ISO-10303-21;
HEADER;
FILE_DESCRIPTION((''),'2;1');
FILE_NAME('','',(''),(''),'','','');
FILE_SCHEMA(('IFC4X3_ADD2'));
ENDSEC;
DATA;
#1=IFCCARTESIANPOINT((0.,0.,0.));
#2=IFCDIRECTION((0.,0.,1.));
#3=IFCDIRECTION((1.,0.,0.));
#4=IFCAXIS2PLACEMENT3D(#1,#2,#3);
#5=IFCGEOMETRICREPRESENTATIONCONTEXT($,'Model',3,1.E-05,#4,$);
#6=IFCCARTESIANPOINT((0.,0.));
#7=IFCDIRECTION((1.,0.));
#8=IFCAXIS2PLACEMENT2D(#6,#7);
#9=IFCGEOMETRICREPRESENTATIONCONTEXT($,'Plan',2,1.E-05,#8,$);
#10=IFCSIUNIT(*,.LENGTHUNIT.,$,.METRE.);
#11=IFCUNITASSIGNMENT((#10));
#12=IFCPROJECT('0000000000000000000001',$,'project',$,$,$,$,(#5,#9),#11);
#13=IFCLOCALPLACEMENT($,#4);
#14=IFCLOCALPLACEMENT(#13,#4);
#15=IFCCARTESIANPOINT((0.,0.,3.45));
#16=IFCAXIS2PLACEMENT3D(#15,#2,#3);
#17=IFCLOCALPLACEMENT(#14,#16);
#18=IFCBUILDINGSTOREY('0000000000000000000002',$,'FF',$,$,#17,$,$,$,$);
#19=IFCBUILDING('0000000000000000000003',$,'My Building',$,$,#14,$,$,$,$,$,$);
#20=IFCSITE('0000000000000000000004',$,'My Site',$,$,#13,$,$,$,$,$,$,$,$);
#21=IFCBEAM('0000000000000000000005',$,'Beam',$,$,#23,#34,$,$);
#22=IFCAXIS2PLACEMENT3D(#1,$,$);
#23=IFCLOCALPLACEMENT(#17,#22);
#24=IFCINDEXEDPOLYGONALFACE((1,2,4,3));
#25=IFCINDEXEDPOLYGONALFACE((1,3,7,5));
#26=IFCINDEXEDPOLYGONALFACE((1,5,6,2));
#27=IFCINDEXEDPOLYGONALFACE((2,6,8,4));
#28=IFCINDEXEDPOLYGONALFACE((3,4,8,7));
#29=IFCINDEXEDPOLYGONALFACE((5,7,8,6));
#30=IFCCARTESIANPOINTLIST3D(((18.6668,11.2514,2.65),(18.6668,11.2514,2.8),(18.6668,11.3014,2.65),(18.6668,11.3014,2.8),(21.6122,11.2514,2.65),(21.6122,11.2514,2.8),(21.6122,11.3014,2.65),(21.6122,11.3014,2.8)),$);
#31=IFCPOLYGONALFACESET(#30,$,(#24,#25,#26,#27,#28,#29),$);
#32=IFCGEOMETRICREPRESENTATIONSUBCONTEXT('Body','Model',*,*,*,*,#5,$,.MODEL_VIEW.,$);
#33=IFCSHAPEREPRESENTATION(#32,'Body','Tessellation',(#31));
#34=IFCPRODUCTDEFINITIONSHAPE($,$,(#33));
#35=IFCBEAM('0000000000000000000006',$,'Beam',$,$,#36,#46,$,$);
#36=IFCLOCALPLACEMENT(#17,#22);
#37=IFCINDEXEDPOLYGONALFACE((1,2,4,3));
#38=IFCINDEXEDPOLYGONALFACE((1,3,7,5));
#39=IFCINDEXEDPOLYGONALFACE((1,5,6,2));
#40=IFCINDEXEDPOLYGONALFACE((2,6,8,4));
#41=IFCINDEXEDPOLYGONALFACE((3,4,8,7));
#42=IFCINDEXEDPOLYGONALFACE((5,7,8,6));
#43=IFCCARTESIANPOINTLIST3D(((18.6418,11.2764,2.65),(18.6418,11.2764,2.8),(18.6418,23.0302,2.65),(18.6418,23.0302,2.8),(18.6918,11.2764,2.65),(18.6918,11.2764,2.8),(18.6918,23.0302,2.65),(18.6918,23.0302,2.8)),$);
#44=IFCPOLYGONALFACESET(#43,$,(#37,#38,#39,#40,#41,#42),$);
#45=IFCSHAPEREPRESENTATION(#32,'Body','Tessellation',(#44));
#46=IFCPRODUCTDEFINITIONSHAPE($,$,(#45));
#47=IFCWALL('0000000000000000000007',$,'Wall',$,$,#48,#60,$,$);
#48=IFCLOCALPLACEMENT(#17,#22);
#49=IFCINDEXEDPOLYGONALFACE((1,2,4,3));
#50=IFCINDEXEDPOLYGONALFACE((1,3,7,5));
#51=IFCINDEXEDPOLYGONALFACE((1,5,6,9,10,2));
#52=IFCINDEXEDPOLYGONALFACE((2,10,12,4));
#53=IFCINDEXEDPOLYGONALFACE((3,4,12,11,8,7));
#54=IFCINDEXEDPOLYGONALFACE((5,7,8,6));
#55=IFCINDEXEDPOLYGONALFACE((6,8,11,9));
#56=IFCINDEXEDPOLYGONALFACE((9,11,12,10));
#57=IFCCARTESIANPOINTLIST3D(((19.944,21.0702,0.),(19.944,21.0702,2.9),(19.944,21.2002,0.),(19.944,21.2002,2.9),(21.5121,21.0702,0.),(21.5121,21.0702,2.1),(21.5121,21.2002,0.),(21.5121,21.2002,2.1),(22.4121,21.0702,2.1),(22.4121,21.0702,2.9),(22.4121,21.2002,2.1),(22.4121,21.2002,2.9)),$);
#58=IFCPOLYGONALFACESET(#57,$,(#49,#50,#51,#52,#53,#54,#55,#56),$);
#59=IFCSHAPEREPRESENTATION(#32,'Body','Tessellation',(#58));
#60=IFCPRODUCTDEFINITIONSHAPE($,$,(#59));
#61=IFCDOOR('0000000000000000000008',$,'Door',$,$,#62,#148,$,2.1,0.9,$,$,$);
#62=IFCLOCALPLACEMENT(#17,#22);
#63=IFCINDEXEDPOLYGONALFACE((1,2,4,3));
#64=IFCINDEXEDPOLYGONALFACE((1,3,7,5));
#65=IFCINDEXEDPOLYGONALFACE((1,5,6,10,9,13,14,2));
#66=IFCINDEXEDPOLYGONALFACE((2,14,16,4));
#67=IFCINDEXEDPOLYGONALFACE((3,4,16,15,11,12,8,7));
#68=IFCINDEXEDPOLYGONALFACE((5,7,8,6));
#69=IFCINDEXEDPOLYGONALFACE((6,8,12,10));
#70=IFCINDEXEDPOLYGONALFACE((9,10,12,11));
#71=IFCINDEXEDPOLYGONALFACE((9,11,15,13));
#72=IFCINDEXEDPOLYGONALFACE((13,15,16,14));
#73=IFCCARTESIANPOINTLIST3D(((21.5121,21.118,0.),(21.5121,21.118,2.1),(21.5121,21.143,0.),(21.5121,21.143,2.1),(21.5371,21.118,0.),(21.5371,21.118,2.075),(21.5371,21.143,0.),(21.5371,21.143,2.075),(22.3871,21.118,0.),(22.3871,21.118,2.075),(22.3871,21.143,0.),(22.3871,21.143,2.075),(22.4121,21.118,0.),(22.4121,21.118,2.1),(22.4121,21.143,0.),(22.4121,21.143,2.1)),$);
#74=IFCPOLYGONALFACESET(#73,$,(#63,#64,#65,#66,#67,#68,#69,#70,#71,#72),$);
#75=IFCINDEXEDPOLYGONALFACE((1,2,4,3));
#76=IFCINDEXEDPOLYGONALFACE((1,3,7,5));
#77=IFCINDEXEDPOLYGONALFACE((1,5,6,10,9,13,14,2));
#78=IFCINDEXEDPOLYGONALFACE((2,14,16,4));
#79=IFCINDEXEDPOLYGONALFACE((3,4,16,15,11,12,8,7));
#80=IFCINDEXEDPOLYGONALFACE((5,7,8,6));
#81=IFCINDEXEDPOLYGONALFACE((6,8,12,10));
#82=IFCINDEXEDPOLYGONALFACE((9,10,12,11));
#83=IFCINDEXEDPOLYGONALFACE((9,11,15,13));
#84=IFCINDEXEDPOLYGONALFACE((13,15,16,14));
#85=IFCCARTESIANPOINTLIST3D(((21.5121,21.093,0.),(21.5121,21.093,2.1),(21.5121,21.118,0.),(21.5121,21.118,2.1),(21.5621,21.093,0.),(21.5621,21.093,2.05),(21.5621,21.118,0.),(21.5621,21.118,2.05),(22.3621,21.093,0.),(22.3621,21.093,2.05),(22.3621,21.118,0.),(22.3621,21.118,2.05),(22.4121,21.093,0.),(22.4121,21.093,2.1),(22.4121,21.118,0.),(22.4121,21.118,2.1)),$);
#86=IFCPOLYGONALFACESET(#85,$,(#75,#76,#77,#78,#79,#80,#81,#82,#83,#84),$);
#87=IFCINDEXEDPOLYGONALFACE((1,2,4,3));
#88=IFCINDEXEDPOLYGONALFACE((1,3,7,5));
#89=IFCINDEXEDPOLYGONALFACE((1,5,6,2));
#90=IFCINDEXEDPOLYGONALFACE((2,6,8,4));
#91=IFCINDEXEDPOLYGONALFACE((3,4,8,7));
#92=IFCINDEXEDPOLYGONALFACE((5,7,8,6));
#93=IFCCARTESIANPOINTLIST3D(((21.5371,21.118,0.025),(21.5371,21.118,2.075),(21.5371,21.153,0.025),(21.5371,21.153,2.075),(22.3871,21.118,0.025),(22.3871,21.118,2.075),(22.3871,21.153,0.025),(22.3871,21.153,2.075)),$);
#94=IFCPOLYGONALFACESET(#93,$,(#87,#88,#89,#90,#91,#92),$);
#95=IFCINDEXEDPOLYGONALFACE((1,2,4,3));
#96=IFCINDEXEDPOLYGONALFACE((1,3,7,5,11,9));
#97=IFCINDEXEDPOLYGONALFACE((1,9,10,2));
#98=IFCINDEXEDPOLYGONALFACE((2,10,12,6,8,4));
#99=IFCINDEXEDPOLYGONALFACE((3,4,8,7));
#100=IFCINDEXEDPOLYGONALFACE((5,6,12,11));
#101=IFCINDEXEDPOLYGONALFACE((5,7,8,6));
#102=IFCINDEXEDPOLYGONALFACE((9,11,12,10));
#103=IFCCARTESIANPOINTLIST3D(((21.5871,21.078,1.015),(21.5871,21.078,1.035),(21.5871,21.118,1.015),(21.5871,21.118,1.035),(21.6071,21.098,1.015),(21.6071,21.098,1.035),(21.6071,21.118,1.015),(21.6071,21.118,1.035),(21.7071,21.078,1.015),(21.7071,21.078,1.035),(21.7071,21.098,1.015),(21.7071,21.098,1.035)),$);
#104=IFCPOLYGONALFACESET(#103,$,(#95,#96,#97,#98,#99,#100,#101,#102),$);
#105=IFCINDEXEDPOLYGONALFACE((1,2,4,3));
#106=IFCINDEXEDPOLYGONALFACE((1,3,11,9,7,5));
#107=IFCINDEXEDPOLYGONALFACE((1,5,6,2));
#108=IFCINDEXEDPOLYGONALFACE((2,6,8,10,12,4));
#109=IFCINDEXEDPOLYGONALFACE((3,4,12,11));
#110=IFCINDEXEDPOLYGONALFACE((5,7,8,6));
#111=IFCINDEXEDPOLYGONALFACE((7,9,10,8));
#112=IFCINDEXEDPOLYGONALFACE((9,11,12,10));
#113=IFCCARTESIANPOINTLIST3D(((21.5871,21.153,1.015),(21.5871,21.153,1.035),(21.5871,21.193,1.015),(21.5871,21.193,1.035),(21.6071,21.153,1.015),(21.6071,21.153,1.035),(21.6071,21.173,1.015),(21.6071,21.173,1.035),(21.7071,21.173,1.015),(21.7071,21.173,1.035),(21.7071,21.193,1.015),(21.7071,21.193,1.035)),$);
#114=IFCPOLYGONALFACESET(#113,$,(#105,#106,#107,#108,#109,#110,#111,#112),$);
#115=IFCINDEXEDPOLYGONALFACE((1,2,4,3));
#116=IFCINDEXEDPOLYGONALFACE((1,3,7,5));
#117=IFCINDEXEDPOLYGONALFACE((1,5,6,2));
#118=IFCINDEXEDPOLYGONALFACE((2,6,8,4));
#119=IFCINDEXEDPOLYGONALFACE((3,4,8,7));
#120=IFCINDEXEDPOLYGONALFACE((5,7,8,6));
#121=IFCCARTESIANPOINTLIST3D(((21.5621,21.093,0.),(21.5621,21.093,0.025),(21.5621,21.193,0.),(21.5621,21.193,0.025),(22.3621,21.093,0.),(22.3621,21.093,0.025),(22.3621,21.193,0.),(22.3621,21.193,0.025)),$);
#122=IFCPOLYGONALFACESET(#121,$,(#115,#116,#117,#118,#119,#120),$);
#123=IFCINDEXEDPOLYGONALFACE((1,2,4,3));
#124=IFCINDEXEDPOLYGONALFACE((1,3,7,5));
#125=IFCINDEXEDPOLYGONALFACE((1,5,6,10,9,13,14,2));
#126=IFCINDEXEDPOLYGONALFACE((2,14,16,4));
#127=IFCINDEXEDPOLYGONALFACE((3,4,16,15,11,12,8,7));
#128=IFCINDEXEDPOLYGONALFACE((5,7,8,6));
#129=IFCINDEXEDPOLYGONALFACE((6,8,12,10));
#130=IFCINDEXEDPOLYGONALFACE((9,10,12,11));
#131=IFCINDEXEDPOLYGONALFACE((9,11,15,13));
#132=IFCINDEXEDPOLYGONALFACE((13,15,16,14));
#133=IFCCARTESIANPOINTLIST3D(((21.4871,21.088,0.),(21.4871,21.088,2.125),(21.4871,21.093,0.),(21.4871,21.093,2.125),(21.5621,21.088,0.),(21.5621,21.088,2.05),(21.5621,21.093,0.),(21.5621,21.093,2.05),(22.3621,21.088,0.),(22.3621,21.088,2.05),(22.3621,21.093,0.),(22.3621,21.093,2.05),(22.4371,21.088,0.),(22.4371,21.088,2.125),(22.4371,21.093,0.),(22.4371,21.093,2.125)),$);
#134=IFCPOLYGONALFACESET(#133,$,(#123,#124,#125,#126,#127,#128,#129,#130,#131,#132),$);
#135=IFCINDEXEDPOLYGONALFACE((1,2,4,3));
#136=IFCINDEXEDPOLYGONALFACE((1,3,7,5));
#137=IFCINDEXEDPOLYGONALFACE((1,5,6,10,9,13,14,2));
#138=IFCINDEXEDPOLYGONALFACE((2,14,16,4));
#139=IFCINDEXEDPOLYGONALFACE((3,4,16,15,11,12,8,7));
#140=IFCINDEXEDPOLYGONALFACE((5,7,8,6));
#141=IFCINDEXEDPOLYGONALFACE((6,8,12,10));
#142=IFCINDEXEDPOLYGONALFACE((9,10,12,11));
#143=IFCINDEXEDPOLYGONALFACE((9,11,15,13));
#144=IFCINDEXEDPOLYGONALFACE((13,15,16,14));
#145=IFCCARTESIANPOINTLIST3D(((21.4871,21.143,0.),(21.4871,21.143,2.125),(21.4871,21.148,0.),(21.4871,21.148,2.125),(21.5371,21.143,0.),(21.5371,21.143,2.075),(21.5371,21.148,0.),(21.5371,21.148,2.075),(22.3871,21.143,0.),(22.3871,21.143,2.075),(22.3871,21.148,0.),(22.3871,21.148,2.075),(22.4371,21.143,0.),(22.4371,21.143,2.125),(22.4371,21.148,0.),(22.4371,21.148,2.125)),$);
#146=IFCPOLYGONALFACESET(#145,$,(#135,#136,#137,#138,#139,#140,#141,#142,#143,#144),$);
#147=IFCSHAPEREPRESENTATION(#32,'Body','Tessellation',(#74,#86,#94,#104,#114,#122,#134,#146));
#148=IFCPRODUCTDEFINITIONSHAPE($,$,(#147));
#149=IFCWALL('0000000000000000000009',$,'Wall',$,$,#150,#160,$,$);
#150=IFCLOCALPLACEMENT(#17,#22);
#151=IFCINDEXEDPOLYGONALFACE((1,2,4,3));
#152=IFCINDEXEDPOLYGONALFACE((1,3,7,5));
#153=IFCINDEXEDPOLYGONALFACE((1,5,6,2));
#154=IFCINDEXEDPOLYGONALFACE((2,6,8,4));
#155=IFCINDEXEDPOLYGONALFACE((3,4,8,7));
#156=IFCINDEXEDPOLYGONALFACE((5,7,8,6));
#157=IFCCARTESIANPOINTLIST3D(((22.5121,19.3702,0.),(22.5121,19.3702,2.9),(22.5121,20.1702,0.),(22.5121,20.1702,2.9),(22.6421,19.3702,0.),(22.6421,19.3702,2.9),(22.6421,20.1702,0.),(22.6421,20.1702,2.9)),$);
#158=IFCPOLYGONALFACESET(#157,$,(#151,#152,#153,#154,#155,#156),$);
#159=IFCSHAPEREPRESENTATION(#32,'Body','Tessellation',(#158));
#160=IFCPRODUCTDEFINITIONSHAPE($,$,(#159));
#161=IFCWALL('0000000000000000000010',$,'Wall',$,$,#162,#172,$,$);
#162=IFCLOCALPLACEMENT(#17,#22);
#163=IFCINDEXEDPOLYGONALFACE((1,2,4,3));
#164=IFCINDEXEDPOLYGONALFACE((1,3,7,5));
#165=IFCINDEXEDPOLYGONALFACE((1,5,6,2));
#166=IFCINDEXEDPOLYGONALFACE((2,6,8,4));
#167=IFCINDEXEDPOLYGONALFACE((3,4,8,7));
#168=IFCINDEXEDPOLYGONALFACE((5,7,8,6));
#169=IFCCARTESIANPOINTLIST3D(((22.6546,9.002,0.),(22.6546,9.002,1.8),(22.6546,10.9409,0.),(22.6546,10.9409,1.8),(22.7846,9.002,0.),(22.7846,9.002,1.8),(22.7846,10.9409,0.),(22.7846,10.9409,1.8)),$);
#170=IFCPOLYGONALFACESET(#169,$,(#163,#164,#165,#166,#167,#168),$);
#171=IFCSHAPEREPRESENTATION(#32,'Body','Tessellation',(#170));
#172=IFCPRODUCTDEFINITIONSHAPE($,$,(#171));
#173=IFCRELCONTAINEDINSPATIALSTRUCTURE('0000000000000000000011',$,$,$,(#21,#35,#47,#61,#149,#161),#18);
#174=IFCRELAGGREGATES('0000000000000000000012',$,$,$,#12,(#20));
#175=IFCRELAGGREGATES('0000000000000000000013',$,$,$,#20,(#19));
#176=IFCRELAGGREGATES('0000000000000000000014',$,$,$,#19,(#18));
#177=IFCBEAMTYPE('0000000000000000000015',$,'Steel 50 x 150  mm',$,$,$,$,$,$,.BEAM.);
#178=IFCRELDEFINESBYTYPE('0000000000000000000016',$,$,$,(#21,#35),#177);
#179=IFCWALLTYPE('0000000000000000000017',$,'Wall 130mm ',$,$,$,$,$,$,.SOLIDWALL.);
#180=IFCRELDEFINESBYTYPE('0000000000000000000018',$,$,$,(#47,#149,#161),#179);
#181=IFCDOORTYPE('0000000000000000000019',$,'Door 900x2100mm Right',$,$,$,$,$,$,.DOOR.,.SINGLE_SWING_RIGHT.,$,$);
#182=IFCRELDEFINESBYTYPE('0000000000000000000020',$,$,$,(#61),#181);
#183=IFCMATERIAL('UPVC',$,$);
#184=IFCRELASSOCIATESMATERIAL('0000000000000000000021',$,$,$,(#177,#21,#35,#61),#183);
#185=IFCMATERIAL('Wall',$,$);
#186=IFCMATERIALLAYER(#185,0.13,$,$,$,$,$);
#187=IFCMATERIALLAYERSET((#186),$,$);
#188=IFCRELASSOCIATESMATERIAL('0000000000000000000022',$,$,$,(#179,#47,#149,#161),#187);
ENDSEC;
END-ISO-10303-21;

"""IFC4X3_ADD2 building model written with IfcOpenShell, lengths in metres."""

from ifc_helpers import new_model, entity, si_unit, frame, origin_with_axes, origin_2d_with_axis, place, context, subcontext, project, spatial, line, indexed_curve, rectangle, outline, extrude, shape, source, transform, mapped, material, layer, layer_set, layer_usage, material_profile, profile_set, profile_usage, type_object, type_shapes, element, fill, save


model = new_model("IFC4X3_ADD2")

# Units and contexts
model_context = context("Model", 3, precision=1e-05, world=origin_with_axes())
plan_context = context("Plan", 2, precision=1e-05, world=origin_2d_with_axis())
body_context_1 = subcontext(model_context, "Body", "Model", "MODEL_VIEW")
body_context_2 = subcontext(plan_context, "Body", "Plan", "PLAN_VIEW")
ifc_project = project(units=[si_unit("LENGTHUNIT", "METRE")], contexts=[model_context, plan_context])

# Site, building, storey
site_placement = place(None, origin_with_axes())
site = spatial("IfcSite", under=ifc_project, at=site_placement, Name="My Site")
building_placement = place(site_placement, origin_with_axes())
building = spatial("IfcBuilding", under=site, at=building_placement, Name="My Building")
storey_placement = place(building_placement, frame((0.0, 0.0, 3.45), z_axis=(0.0, 0.0, 1.0), x_axis=(1.0, 0.0, 0.0)))
storey = spatial("IfcBuildingStorey", under=building, at=storey_placement, Name="FF")

# Beams
ifc_material_1 = material(Name="UPVC")
ifc_material_profile = material_profile(ifc_material_1, rectangle(XDim=0.05, YDim=0.15))
ifc_profile_set = profile_set([ifc_material_profile])
ifc_profile_usage_1 = profile_usage(ifc_profile_set)
beam_type = type_object("IfcBeamType", Name="Steel 50 x 150  mm", PredefinedType="BEAM", material=ifc_profile_set)
beam_1_placement = place(storey_placement, frame((18.6668, 11.2764, 2.725), z_axis=(1.0, 0.0, 0.0), x_axis=(0.0, 1.0, 0.0)))
element("IfcBeam", 1, at=beam_1_placement, inside=storey, type_object=beam_type, material=ifc_profile_usage_1, Name="Beam", context=body_context_1, shape_type="SweptSolid", body=[
    extrude(rectangle(XDim=0.05, YDim=0.15), origin_with_axes(), (0.0, 0.0, 1.0), 2.9454),
])
ifc_profile_usage_2 = profile_usage(ifc_profile_set)
beam_2_placement = place(storey_placement, frame((18.6668, 11.2764, 2.725), z_axis=(0.0, 1.0, 0.0), x_axis=(-1.0, 0.0, 0.0)))
element("IfcBeam", 2, at=beam_2_placement, inside=storey, type_object=beam_type, material=ifc_profile_usage_2, Name="Beam", context=body_context_1, shape_type="SweptSolid", body=[
    extrude(rectangle(XDim=0.05, YDim=0.15), origin_with_axes(), (0.0, 0.0, 1.0), 11.7538),
])

# Wall, opening, door
ifc_material_2 = material(Name="Wall")
ifc_layer_1 = layer(ifc_material_2, 0.13)
ifc_layer_set_1 = layer_set([ifc_layer_1])
ifc_layer_usage_1 = layer_usage(ifc_layer_set_1, "AXIS2", "POSITIVE", 0.0)
wall_type_1 = type_object("IfcWallType", Name="Wall 130mm ", PredefinedType="SOLIDWALL", material=ifc_layer_set_1)
wall_1_placement = place(storey_placement, frame((22.4121, 21.2002, 0.0), z_axis=(0.0, 0.0, 1.0), x_axis=(-1.0, 0.0, 0.0)))
wall_1 = element("IfcWall", 3, at=wall_1_placement, inside=storey, type_object=wall_type_1, material=ifc_layer_usage_1, Name="Wall", context=body_context_1, shape_type="SweptSolid", body=[
    extrude(outline(indexed_curve([(0.0, 0.0), (0.0, 0.13), (2.4681, 0.13), (2.4681, 0.0), (0.0, 0.0)], self_intersect=False)), origin_with_axes(), (0.0, 0.0, 1.0), 2.9),
])
shared_shape_1 = source(origin_with_axes(), body_context_1, "Body", "SweptSolid", [
    extrude(outline(indexed_curve([(0.0, 0.0), (0.9, 0.0), (0.9, 2.1), (0.0, 2.1)], segments=[line(1, 2, 3, 4, 1)])), frame((0.0, -0.6, 0.0), z_axis=(0.0, -1.0, 0.0), x_axis=(1.0, 0.0, 0.0)), (0.0, 0.0, -1.0), 1.2),
])
opening_1_placement = place(wall_1_placement, frame((0.9, 0.1072, 0.0), z_axis=(0.0, 0.0, 1.0), x_axis=(-1.0, 0.0, 0.0)))
opening_1 = element("IfcOpeningElement", 4, at=opening_1_placement, cuts=wall_1, PredefinedType="OPENING", context=body_context_1, shape_type="MappedRepresentation", body=[
    mapped(shared_shape_1, transform((0.0, 0.0, 0.0), x_axis=(1.0, 0.0, 0.0), y_axis=(0.0, 1.0, 0.0), z_axis=(0.0, 0.0, 1.0), scale=1.0)),
])
door_type_1 = type_object("IfcDoorType", Name="Door 900x2100mm Right", OperationType="SINGLE_SWING_RIGHT", PredefinedType="DOOR")
shared_shape_2 = source(origin_with_axes(), body_context_1, "Body", "SweptSolid", [
    extrude(outline(indexed_curve([(0.0, 0.0), (0.0, 2.1), (0.9, 2.1), (0.9, 0.0), (0.875, 0.0), (0.875, 2.075), (0.025, 2.075), (0.025, 0.0)], segments=[line(1, 2, 3, 4, 5, 6, 7, 8, 1)])), frame((0.0, 0.025, 0.0), z_axis=(0.0, -1.0, 0.0), x_axis=(1.0, 0.0, 0.0)), (0.0, 0.0, -1.0), 0.025),
    extrude(outline(indexed_curve([(0.0, 0.0), (0.0, 2.1), (0.9, 2.1), (0.9, 0.0), (0.85, 0.0), (0.85, 2.05), (0.05, 2.05), (0.05, 0.0)], segments=[line(1, 2, 3, 4, 5, 6, 7, 8, 1)])), frame((0.0, 0.0, 0.0), z_axis=(0.0, -1.0, 0.0), x_axis=(1.0, 0.0, 0.0)), (0.0, 0.0, -1.0), 0.025),
    extrude(outline(indexed_curve([(0.0, 0.0), (0.85, 0.0), (0.85, 0.035), (0.0, 0.035)], segments=[line(1, 2, 3, 4, 1)])), frame((0.025, 0.025, 0.025), z_axis=(0.0, 0.0, 1.0), x_axis=(1.0, 0.0, 0.0)), (0.0, 0.0, 1.0), 2.05),
    extrude(outline(indexed_curve([(0.0, 0.0), (0.0, -0.04), (0.12, -0.04), (0.12, -0.02), (0.02, -0.02), (0.02, 0.0)], segments=[line(1, 2, 3, 4, 5, 6, 1)])), frame((0.075, 0.025, 1.015), z_axis=(0.0, 0.0, 1.0), x_axis=(1.0, 0.0, 0.0)), (0.0, 0.0, 1.0), 0.02),
    extrude(outline(indexed_curve([(0.0, 0.0), (0.0, 0.04), (0.12, 0.04), (0.12, 0.02), (0.02, 0.02), (0.02, 0.0)], segments=[line(1, 2, 3, 4, 5, 6, 1)])), frame((0.075, 0.06, 1.015), z_axis=(0.0, 0.0, 1.0), x_axis=(1.0, 0.0, 0.0)), (0.0, 0.0, 1.0), 0.02),
    extrude(outline(indexed_curve([(0.0, 0.0), (0.8, 0.0), (0.8, 0.1), (0.0, 0.1)], segments=[line(1, 2, 3, 4, 1)])), frame((0.05, 0.0, 0.0), z_axis=(0.0, 0.0, 1.0), x_axis=(1.0, 0.0, 0.0)), (0.0, 0.0, 1.0), 0.025),
    extrude(outline(indexed_curve([(0.0, 0.0), (0.0, 2.125), (0.95, 2.125), (0.95, 0.0), (0.875, 0.0), (0.875, 2.05), (0.075, 2.05), (0.075, 0.0)], segments=[line(1, 2, 3, 4, 5, 6, 7, 8, 1)])), frame((-0.025, -0.005, 0.0), z_axis=(0.0, -1.0, 0.0), x_axis=(1.0, 0.0, 0.0)), (0.0, 0.0, -1.0), 0.005),
    extrude(outline(indexed_curve([(0.0, 0.0), (0.0, 2.125), (0.95, 2.125), (0.95, 0.0), (0.9, 0.0), (0.9, 2.075), (0.05, 2.075), (0.05, 0.0)], segments=[line(1, 2, 3, 4, 5, 6, 7, 8, 1)])), frame((-0.025, 0.05, 0.0), z_axis=(0.0, -1.0, 0.0), x_axis=(1.0, 0.0, 0.0)), (0.0, 0.0, -1.0), 0.005),
])
shared_shape_3 = source(origin_with_axes(), body_context_2, "Body", "Curve2D", [
    entity("IfcIndexedPolyCurve", entity("IfcCartesianPointList2D", [[0.0, 0.0], [0.0, 0.05], [0.025, 0.05], [0.025, 0.025], [0.05, 0.025], [0.05, 0.0]]), [entity("IfcLineIndex", [1, 2, 3, 4, 5, 6, 1])]),
    entity("IfcIndexedPolyCurve", entity("IfcCartesianPointList2D", [[0.9, 0.0], [0.9, 0.05], [0.875, 0.05], [0.875, 0.025], [0.85, 0.025], [0.85, 0.0]]), [entity("IfcLineIndex", [1, 2, 3, 4, 5, 6, 1])]),
    entity("IfcTrimmedCurve", entity("IfcEllipse", entity("IfcAxis2Placement2D", entity("IfcCartesianPoint", [0.84, 0.05]), entity("IfcDirection", [1.0, 0.0])), 0.815, 0.85), [entity("IfcCartesianPoint", [0.84, 0.9])], [entity("IfcCartesianPoint", [0.025, 0.05])], True, "CARTESIAN"),
    entity("IfcIndexedPolyCurve", entity("IfcCartesianPointList2D", [[0.875, 0.05], [0.84, 0.05], [0.84, 0.9], [0.875, 0.9]]), [entity("IfcLineIndex", [1, 2, 3, 4, 1])]),
])
type_shapes(door_type_1, [shared_shape_2, shared_shape_3])
door_1_placement = place(opening_1_placement, frame((0.0, 0.0, 0.0), z_axis=(0.0, 0.0, 1.0), x_axis=(1.0, 0.0, 0.0)))
door_1 = element("IfcDoor", 5, at=door_1_placement, inside=storey, type_object=door_type_1, material=ifc_material_1, Name="Door", OverallHeight=2.1, OverallWidth=0.9, shapes=[
    shape(body_context_1, "Body", "MappedRepresentation", [mapped(shared_shape_2, transform((0.0, 0.0, 0.0), x_axis=(1.0, 0.0, 0.0), y_axis=(0.0, 1.0, 0.0), z_axis=(0.0, 0.0, 1.0), scale=1.0))]),
    shape(body_context_2, "Body", "MappedRepresentation", [mapped(shared_shape_3, transform((0.0, 0.0, 0.0), x_axis=(1.0, 0.0, 0.0), y_axis=(0.0, 1.0, 0.0), z_axis=(0.0, 0.0, 1.0), scale=1.0))]),
])
fill(opening_1, door_1)

# Walls
ifc_layer_usage_2 = layer_usage(ifc_layer_set_1, "AXIS2", "POSITIVE", 0.0)
wall_2_placement = place(storey_placement, frame((22.6421, 19.3702, 0.0), z_axis=(0.0, 0.0, 1.0), x_axis=(0.000001, 1.0, 0.0)))
element("IfcWall", 6, at=wall_2_placement, inside=storey, type_object=wall_type_1, material=ifc_layer_usage_2, Name="Wall", context=body_context_1, shape_type="SweptSolid", body=[
    extrude(outline(indexed_curve([(0.0, 0.0), (0.0, 0.13), (0.8, 0.13), (0.8, 0.0), (0.0, 0.0)], self_intersect=False)), origin_with_axes(), (0.0, 0.0, 1.0), 2.9),
])
ifc_layer_usage_3 = layer_usage(ifc_layer_set_1, "AXIS2", "POSITIVE", 0.0)
wall_3_placement = place(storey_placement, frame((22.7846, 9.002, 0.0), z_axis=(0.0, 0.0, 1.0), x_axis=(0.0, 1.0, 0.0)))
element("IfcWall", 7, at=wall_3_placement, inside=storey, type_object=wall_type_1, material=ifc_layer_usage_3, Name="Wall", context=body_context_1, shape_type="SweptSolid", body=[
    extrude(outline(indexed_curve([(0.0, 0.0), (0.0, 0.13), (1.9389, 0.13), (1.9389, 0.0), (0.0, 0.0)], self_intersect=False)), origin_with_axes(), (0.0, 0.0, 1.0), 1.8),
])

save(model, "model.ifc")
